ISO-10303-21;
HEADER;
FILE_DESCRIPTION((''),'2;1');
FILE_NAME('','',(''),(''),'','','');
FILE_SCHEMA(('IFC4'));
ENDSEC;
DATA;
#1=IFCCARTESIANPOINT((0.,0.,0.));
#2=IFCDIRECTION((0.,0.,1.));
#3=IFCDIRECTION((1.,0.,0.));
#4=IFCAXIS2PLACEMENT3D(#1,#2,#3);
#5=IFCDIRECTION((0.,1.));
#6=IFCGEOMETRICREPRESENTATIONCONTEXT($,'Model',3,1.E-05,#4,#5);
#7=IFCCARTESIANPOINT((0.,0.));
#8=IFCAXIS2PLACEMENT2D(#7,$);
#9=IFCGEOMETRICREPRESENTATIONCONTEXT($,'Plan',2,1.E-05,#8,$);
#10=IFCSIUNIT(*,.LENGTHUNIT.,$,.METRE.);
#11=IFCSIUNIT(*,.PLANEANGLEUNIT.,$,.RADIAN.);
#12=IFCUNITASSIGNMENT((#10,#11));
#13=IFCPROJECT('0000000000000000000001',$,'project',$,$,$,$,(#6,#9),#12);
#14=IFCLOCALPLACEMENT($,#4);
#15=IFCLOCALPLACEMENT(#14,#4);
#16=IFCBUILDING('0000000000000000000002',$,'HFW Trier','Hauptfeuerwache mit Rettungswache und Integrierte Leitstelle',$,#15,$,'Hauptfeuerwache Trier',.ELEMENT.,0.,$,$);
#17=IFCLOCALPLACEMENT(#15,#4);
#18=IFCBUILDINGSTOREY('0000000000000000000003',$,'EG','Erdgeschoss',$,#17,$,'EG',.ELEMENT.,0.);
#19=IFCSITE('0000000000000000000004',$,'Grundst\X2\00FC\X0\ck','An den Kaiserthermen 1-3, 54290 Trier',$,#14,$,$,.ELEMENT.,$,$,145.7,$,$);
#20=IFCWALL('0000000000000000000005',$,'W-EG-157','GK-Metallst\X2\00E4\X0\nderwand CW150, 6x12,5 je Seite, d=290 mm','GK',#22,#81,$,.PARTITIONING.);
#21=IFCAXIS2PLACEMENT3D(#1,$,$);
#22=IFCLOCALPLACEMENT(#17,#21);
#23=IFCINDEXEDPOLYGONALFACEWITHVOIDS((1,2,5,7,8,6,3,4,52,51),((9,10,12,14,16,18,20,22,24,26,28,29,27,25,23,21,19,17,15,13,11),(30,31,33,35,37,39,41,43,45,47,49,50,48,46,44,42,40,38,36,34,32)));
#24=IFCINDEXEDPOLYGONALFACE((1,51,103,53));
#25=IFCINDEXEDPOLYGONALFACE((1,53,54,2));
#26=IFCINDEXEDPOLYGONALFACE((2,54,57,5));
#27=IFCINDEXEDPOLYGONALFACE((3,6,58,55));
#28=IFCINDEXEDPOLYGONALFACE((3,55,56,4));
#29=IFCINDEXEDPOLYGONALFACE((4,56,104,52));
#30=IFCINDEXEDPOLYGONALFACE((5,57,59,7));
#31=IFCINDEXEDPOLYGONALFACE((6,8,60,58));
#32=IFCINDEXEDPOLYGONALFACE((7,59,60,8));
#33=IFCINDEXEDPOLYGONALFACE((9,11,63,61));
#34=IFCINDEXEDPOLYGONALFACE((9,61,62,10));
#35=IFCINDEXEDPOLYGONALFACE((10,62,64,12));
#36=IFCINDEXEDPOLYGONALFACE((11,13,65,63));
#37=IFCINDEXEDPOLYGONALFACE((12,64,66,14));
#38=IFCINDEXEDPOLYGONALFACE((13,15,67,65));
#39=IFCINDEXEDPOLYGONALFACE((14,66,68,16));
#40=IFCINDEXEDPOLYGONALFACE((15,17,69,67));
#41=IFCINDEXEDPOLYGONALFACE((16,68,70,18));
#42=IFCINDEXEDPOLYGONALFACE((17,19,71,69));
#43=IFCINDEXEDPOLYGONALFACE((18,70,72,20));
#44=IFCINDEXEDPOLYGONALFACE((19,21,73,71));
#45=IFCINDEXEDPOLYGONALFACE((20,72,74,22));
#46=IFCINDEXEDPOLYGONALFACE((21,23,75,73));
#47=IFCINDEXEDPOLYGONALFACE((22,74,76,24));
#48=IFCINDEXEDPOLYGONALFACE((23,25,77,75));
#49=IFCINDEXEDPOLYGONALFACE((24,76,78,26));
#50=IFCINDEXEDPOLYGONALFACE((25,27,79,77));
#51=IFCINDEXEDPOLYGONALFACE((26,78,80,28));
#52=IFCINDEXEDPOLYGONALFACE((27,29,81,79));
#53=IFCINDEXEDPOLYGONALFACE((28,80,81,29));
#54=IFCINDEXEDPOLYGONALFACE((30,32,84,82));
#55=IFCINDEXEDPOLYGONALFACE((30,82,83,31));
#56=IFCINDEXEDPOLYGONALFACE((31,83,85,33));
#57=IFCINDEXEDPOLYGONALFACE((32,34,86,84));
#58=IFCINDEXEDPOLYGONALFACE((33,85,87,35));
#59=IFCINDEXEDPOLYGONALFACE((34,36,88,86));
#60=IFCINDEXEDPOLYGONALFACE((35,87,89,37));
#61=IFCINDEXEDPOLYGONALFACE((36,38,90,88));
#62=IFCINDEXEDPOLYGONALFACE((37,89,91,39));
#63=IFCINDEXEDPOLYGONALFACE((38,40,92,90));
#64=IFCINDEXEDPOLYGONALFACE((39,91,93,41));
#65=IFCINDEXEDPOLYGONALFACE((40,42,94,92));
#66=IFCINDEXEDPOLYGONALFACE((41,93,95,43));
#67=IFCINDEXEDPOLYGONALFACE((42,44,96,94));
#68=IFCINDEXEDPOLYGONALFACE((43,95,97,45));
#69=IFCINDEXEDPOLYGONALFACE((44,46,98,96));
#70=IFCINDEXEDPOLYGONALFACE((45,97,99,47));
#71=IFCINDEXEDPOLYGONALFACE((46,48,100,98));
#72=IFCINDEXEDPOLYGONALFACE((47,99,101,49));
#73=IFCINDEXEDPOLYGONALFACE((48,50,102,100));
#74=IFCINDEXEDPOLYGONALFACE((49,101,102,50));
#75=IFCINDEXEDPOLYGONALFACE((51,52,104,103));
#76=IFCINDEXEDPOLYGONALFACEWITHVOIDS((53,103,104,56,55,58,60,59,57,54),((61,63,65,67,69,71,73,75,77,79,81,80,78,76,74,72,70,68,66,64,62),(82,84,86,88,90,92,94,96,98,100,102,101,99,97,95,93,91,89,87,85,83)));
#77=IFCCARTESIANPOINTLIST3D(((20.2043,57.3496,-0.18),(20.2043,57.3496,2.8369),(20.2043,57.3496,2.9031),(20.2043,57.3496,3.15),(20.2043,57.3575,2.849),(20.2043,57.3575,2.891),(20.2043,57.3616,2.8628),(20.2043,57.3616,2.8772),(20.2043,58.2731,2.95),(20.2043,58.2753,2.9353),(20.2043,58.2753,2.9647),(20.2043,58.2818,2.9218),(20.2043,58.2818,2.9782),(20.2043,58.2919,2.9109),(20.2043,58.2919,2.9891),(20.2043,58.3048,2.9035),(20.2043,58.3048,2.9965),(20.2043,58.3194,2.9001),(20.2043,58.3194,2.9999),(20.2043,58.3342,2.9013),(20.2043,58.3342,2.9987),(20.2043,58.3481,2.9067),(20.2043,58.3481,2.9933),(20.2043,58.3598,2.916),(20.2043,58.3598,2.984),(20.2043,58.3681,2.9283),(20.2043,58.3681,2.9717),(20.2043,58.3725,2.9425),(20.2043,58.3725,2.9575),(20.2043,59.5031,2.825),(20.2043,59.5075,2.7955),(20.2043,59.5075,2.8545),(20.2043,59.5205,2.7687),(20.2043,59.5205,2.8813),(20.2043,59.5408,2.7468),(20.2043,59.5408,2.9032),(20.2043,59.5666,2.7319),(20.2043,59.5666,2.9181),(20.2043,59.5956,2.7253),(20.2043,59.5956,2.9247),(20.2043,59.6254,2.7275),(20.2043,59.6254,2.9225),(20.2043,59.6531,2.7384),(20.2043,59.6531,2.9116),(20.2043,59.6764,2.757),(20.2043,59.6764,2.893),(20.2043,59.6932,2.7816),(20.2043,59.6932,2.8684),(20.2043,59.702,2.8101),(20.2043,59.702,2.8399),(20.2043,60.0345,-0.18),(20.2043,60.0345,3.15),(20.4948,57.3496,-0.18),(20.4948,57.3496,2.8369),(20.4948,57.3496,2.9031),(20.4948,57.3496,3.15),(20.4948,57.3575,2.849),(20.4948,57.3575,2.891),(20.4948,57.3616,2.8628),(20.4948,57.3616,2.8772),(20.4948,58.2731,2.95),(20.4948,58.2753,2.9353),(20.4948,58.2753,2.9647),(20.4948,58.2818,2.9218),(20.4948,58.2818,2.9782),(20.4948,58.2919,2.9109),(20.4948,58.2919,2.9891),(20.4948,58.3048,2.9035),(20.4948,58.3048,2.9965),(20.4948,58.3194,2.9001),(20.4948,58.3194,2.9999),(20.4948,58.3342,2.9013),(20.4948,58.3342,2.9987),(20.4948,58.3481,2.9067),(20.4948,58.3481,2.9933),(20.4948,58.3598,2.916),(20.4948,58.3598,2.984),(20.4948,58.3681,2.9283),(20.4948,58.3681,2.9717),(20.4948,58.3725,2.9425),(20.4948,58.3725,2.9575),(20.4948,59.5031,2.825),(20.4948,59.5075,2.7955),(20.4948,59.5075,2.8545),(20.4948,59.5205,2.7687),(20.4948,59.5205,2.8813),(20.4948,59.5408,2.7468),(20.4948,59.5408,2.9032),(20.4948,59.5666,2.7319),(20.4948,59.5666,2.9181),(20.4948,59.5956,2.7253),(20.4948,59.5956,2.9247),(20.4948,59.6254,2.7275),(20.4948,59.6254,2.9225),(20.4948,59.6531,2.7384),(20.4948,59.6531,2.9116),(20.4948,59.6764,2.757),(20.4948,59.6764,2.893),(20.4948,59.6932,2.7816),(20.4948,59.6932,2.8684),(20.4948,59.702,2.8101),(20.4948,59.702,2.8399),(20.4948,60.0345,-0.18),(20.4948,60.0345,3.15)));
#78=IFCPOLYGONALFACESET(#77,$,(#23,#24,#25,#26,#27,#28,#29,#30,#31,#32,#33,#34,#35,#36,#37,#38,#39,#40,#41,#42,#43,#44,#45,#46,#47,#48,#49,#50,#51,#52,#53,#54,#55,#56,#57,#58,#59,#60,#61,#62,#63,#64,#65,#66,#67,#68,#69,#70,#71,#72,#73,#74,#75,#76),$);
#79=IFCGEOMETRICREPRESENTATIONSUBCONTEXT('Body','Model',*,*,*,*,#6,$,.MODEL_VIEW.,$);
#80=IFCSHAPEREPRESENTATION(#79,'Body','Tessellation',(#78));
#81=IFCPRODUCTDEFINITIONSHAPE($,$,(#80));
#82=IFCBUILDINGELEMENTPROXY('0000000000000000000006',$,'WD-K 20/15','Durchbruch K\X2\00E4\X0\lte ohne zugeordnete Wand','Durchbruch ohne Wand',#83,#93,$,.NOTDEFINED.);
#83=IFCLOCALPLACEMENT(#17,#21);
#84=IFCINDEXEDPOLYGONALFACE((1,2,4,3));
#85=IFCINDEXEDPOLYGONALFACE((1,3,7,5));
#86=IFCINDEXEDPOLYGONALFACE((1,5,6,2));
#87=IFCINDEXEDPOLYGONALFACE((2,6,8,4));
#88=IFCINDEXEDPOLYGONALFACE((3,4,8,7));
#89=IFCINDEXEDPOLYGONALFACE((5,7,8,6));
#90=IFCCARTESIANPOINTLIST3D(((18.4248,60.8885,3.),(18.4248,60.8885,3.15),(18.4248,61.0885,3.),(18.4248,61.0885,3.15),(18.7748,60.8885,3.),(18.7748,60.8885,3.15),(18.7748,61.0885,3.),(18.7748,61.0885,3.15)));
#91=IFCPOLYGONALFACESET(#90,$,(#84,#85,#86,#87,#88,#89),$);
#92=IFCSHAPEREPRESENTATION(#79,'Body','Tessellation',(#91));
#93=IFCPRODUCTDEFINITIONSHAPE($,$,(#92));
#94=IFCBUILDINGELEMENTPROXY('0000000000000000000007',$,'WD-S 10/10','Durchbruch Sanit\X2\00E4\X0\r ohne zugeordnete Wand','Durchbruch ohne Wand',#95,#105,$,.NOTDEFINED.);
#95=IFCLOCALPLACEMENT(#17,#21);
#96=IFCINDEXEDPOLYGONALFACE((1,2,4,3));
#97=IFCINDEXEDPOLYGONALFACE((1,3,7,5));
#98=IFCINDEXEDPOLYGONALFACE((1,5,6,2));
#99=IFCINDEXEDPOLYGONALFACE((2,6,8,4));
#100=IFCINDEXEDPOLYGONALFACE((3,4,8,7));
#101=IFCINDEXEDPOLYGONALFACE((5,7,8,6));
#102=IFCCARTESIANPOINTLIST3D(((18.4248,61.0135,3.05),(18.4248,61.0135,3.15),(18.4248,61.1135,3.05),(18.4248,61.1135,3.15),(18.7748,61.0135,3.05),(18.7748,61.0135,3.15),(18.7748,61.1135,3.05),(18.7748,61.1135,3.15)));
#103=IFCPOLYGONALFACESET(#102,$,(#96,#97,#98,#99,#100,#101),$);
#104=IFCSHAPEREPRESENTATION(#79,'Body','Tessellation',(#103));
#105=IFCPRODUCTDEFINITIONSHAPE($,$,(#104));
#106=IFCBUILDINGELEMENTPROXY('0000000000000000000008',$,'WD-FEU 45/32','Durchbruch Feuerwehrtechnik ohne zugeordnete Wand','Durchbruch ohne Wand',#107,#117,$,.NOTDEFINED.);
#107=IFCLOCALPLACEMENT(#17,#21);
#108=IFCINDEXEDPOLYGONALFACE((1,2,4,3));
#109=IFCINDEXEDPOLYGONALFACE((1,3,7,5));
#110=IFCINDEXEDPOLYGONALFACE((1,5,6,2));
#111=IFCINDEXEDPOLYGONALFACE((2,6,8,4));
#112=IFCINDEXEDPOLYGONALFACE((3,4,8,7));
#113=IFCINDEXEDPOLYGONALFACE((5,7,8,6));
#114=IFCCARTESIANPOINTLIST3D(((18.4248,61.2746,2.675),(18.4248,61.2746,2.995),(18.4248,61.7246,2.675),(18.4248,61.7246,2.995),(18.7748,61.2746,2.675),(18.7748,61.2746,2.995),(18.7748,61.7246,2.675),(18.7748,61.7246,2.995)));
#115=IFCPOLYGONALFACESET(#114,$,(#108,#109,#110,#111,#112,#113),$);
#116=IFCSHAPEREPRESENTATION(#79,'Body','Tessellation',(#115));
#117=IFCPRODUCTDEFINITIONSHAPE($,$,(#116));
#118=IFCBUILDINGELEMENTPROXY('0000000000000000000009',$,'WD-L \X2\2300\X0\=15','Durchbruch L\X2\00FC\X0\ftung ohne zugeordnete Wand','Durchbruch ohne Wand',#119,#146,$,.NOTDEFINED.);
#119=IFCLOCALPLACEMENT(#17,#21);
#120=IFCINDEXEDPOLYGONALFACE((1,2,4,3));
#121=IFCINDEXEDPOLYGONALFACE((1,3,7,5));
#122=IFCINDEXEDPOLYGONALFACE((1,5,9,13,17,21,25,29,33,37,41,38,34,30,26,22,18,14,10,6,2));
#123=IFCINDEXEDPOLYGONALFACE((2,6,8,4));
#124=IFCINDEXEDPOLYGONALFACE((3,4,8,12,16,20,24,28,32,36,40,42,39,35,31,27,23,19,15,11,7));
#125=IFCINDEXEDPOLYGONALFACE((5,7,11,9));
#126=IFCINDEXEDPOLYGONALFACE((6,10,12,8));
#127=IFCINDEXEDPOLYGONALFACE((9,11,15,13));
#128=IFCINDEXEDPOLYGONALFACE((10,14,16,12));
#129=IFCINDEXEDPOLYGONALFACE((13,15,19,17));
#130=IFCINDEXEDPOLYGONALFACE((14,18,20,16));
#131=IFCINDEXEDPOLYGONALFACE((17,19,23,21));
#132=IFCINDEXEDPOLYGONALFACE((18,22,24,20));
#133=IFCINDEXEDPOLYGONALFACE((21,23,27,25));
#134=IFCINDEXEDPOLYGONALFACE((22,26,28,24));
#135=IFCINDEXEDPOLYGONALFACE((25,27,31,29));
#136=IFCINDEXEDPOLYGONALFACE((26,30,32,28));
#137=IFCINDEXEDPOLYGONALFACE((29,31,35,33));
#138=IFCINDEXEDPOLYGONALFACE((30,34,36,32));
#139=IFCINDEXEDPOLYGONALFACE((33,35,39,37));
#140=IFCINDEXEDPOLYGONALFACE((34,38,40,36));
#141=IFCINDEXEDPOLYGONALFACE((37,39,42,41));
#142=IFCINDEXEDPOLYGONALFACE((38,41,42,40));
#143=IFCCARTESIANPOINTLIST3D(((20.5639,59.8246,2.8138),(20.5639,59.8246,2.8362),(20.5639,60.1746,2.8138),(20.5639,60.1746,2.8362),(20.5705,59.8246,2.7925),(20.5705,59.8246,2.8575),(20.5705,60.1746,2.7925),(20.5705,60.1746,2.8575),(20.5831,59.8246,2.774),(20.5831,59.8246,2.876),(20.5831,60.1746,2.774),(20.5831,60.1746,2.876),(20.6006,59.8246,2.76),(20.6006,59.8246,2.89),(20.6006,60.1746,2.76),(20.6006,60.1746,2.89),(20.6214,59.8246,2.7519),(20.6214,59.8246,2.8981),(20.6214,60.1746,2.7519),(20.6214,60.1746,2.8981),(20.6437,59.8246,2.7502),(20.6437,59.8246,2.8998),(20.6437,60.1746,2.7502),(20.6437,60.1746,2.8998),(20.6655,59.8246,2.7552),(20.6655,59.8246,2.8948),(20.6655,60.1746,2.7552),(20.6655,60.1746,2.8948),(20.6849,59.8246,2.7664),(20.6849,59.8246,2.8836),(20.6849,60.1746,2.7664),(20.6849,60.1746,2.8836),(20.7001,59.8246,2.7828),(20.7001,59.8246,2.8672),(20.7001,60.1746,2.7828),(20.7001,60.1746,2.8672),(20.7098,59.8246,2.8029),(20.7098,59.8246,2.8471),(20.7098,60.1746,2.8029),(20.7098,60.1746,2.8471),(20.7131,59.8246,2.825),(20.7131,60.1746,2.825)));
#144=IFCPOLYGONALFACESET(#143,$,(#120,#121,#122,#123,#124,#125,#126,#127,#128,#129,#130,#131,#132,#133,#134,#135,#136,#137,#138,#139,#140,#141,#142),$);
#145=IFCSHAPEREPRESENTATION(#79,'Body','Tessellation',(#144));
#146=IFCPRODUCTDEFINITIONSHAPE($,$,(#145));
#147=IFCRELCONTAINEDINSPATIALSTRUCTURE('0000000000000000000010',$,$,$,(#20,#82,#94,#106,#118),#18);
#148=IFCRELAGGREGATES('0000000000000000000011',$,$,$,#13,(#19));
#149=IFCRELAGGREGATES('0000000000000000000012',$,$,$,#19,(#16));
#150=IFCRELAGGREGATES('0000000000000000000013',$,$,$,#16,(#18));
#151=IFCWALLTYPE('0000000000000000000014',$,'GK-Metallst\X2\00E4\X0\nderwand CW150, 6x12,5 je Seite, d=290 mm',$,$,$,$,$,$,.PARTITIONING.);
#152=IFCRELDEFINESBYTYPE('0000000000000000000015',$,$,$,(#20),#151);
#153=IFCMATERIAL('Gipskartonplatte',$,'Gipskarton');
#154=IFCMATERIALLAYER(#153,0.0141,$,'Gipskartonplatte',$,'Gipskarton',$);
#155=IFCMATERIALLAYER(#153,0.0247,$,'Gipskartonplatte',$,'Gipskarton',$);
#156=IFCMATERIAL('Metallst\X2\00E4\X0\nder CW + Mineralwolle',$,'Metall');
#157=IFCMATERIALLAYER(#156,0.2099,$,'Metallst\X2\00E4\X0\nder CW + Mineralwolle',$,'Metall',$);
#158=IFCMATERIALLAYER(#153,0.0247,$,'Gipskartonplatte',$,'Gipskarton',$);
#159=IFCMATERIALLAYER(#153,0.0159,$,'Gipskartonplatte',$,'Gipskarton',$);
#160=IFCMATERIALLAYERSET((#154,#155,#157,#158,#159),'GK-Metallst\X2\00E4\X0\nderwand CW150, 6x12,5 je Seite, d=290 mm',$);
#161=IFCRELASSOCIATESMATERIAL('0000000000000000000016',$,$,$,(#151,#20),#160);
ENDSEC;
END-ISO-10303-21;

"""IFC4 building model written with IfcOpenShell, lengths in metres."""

from ifc_helpers import new_model, si_unit, direction, frame, frame_2d, origin_with_axes, origin_2d, place, context, subcontext, project, spatial, rectangle, circle, extrude, material, layer, layer_set, layer_usage, type_object, element, save


model = new_model("IFC4")

# Units and contexts
model_context = context("Model", 3, precision=1e-05, world=origin_with_axes(), true_north=direction((0.0, 1.0)))
plan_context = context("Plan", 2, precision=1e-05, world=origin_2d())
body_context = subcontext(model_context, "Body", "Model", "MODEL_VIEW")
ifc_project = project(units=[si_unit("LENGTHUNIT", "METRE"), si_unit("PLANEANGLEUNIT", "RADIAN")], contexts=[model_context, plan_context])

# Site, building, storey
site_placement = place(None, origin_with_axes())
site = spatial("IfcSite", under=ifc_project, at=site_placement, Name="Grundstück", Description="An den Kaiserthermen 1-3, 54290 Trier", CompositionType="ELEMENT", RefElevation=145.7)
building_placement = place(site_placement, origin_with_axes())
building = spatial("IfcBuilding", under=site, at=building_placement, Name="HFW Trier", Description="Hauptfeuerwache mit Rettungswache und Integrierte Leitstelle", LongName="Hauptfeuerwache Trier", CompositionType="ELEMENT", ElevationOfRefHeight=0.0)
storey_placement = place(building_placement, origin_with_axes())
storey = spatial("IfcBuildingStorey", under=building, at=storey_placement, Name="EG", Description="Erdgeschoss", LongName="EG", CompositionType="ELEMENT", Elevation=0.0)

# Shared definitions
ifc_material_1 = material(Name="Gipskartonplatte", Category="Gipskarton")
ifc_material_2 = material(Name="Metallständer CW + Mineralwolle", Category="Metall")

# Wall, openings
ifc_layer_1 = layer(ifc_material_1, 0.0141, Name="Gipskartonplatte", Category="Gipskarton")
ifc_layer_2 = layer(ifc_material_1, 0.0247, Name="Gipskartonplatte", Category="Gipskarton")
ifc_layer_3 = layer(ifc_material_2, 0.2099, Name="Metallständer CW + Mineralwolle", Category="Metall")
ifc_layer_4 = layer(ifc_material_1, 0.0247, Name="Gipskartonplatte", Category="Gipskarton")
ifc_layer_5 = layer(ifc_material_1, 0.0159, Name="Gipskartonplatte", Category="Gipskarton")
ifc_layer_set_1 = layer_set([ifc_layer_1, ifc_layer_2, ifc_layer_3, ifc_layer_4, ifc_layer_5], Name="GK-Metallständerwand CW150, 6x12,5 je Seite, d=290 mm")
ifc_layer_usage_1 = layer_usage(ifc_layer_set_1, "AXIS2", "POSITIVE", -0.1452)
wall_type_1 = type_object("IfcWallType", Name="GK-Metallständerwand CW150, 6x12,5 je Seite, d=290 mm", PredefinedType="PARTITIONING", material=ifc_layer_set_1)
wall_1_placement = place(storey_placement, frame((20.3496, 60.0345, -0.18), z_axis=(0.0, 0.0, 1.0), x_axis=(0.0, -1.0, 0.0)))
wall_1 = element("IfcWall", 1, at=wall_1_placement, inside=storey, type_object=wall_type_1, material=ifc_layer_usage_1, Name="W-EG-157", Description="GK-Metallständerwand CW150, 6x12,5 je Seite, d=290 mm", ObjectType="GK", PredefinedType="PARTITIONING", context=body_context, shape_type="SweptSolid", body=[
    extrude(rectangle(XDim=2.6849, YDim=0.2905, at=frame_2d((1.3424, 0.0))), origin_with_axes(), (0.0, 0.0, 1.0), 3.33),
])
opening_1_placement = place(wall_1_placement, origin_with_axes())
element("IfcOpeningElement", 2, at=opening_1_placement, cuts=wall_1, ObjectType="Wanddurchbruch", PredefinedType="OPENING", context=body_context, shape_type="SweptSolid", body=[
    extrude(circle(Radius=0.1, at=origin_2d()), frame((0.4314, -0.1952, 3.005), z_axis=(0.0, 1.0, 0.0), x_axis=(1.0, 0.0, 0.0)), (0.0, 0.0, 1.0), 0.3905),
])
opening_2_placement = place(wall_1_placement, origin_with_axes())
element("IfcOpeningElement", 3, at=opening_2_placement, cuts=wall_1, ObjectType="Wanddurchbruch", PredefinedType="OPENING", context=body_context, shape_type="SweptSolid", body=[
    extrude(circle(Radius=0.05, at=origin_2d()), frame((2.7224, -0.1952, 3.05), z_axis=(0.0, 1.0, 0.0), x_axis=(1.0, 0.0, 0.0)), (0.0, 0.0, 1.0), 0.3905),
])
opening_3_placement = place(wall_1_placement, origin_with_axes())
element("IfcOpeningElement", 4, at=opening_3_placement, cuts=wall_1, ObjectType="Wanddurchbruch", PredefinedType="OPENING", context=body_context, shape_type="SweptSolid", body=[
    extrude(circle(Radius=0.05, at=origin_2d()), frame((1.7114, -0.1952, 3.13), z_axis=(0.0, 1.0, 0.0), x_axis=(1.0, 0.0, 0.0)), (0.0, 0.0, 1.0), 0.3905),
])

# Building element proxies
proxy_1_placement = place(storey_placement, frame((18.5998, 60.9885, 3.0), z_axis=(0.0, 0.0, 1.0), x_axis=(0.0, 1.0, 0.0)))
element("IfcBuildingElementProxy", 5, at=proxy_1_placement, inside=storey, Name="WD-K 20/15", Description="Durchbruch Kälte ohne zugeordnete Wand", ObjectType="Durchbruch ohne Wand", PredefinedType="NOTDEFINED", context=body_context, shape_type="SweptSolid", body=[
    extrude(rectangle(XDim=0.2, YDim=0.35, at=origin_2d()), origin_with_axes(), (0.0, 0.0, 1.0), 0.15),
])
proxy_2_placement = place(storey_placement, frame((18.5998, 61.0635, 3.05), z_axis=(0.0, 0.0, 1.0), x_axis=(0.0, 1.0, 0.0)))
element("IfcBuildingElementProxy", 6, at=proxy_2_placement, inside=storey, Name="WD-S 10/10", Description="Durchbruch Sanitär ohne zugeordnete Wand", ObjectType="Durchbruch ohne Wand", PredefinedType="NOTDEFINED", context=body_context, shape_type="SweptSolid", body=[
    extrude(rectangle(XDim=0.1, YDim=0.35, at=origin_2d()), origin_with_axes(), (0.0, 0.0, 1.0), 0.1),
])
proxy_3_placement = place(storey_placement, frame((18.5998, 61.4996, 2.675), z_axis=(0.0, 0.0, 1.0), x_axis=(0.0, 1.0, 0.0)))
element("IfcBuildingElementProxy", 7, at=proxy_3_placement, inside=storey, Name="WD-FEU 45/32", Description="Durchbruch Feuerwehrtechnik ohne zugeordnete Wand", ObjectType="Durchbruch ohne Wand", PredefinedType="NOTDEFINED", context=body_context, shape_type="SweptSolid", body=[
    extrude(rectangle(XDim=0.45, YDim=0.35, at=origin_2d()), origin_with_axes(), (0.0, 0.0, 1.0), 0.32),
])
proxy_4_placement = place(storey_placement, frame((20.6381, 59.9996, 2.75), z_axis=(0.0, 0.0, 1.0), x_axis=(1.0, 0.0, 0.0)))
element("IfcBuildingElementProxy", 8, at=proxy_4_placement, inside=storey, Name="WD-L ⌀=15", Description="Durchbruch Lüftung ohne zugeordnete Wand", ObjectType="Durchbruch ohne Wand", PredefinedType="NOTDEFINED", context=body_context, shape_type="SweptSolid", body=[
    extrude(circle(Radius=0.075, at=origin_2d()), frame((0.0, -0.175, 0.075), z_axis=(0.0, 1.0, 0.0), x_axis=(1.0, 0.0, 0.0)), (0.0, 0.0, 1.0), 0.35),
])

save(model, "model.ifc")
